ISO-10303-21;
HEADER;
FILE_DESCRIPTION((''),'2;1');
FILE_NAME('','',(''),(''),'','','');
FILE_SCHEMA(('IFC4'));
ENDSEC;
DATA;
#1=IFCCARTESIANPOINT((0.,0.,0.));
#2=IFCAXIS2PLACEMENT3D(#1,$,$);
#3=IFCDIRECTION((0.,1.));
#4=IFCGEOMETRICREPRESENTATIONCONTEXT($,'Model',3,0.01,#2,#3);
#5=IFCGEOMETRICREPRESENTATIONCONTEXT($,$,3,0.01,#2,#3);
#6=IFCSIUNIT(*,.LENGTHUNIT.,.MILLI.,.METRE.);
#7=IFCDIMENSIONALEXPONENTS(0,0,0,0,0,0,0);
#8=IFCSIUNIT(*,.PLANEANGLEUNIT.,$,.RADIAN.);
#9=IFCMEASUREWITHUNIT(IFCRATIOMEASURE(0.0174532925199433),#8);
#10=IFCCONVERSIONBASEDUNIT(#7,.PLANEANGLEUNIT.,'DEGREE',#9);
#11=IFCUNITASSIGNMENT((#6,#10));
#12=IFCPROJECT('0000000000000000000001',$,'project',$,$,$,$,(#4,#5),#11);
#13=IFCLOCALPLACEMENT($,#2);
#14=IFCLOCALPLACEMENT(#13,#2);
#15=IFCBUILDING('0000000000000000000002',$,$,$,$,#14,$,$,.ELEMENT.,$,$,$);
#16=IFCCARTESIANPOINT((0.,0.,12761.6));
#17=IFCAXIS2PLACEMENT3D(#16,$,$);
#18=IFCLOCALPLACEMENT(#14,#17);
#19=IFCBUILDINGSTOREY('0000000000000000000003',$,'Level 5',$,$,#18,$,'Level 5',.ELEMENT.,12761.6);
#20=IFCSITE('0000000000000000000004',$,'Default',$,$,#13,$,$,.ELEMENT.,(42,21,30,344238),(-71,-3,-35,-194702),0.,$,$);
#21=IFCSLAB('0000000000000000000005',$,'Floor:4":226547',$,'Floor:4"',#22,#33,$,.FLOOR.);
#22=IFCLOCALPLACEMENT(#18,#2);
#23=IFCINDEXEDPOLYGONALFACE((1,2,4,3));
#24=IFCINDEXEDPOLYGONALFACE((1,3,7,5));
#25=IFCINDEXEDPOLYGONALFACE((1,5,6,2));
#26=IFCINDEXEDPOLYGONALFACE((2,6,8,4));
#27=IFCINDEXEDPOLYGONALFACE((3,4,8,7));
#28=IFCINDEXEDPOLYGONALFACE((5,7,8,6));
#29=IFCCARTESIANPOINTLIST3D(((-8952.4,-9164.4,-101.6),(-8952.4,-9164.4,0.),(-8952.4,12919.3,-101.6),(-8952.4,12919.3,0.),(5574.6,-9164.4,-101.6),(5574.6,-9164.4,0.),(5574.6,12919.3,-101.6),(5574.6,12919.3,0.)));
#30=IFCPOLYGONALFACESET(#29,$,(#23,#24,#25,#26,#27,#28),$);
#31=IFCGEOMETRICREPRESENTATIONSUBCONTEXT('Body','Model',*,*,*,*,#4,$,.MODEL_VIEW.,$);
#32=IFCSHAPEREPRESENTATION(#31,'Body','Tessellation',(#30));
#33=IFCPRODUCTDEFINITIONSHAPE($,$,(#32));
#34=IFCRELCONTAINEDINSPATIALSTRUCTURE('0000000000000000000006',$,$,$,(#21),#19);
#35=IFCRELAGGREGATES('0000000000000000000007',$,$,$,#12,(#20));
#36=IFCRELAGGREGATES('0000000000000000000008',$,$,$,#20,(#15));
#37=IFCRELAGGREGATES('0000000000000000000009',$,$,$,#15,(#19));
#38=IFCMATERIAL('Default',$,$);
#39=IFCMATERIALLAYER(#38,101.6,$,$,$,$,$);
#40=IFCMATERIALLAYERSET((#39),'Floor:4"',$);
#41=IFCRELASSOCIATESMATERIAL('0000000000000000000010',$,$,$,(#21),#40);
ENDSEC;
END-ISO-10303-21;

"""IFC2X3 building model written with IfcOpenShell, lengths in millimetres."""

from ifc_helpers import new_model, entity, si_unit, converted_unit, direction, frame, frame_2d, origin, place, context, subcontext, project, spatial, rectangle, extrude, material, layer, layer_set, layer_usage, element, save


model = new_model("IFC2X3")

# Units and contexts
model_context = context("Model", 3, precision=0.01, world=origin(), true_north=direction((0.0, 1.0)))
context_of_model = context(None, 3, precision=0.01, world=origin(), true_north=direction((0.0, 1.0)))
body_context = subcontext(model_context, "Body", "Model", "MODEL_VIEW")
ifc_project = project(units=[si_unit("LENGTHUNIT", "METRE", prefix="MILLI"), converted_unit("PLANEANGLEUNIT", "DEGREE", entity("IfcRatioMeasure", 0.0174532925199433), si_unit("PLANEANGLEUNIT", "RADIAN"), dimensions=[0, 0, 0, 0, 0, 0, 0])], contexts=[model_context, context_of_model])

# Site, building, storey
site_placement = place(None, origin())
site = spatial("IfcSite", under=ifc_project, at=site_placement, Name="Default", CompositionType="ELEMENT", RefLatitude=(42, 21, 30, 344238), RefLongitude=(-71, -3, -35, -194702), RefElevation=0.0)
building_placement = place(site_placement, origin())
building = spatial("IfcBuilding", under=site, at=building_placement, CompositionType="ELEMENT")
storey_placement = place(building_placement, frame((0.0, 0.0, 12761.6)))
storey = spatial("IfcBuildingStorey", under=building, at=storey_placement, Name="Level 5", LongName="Level 5", CompositionType="ELEMENT", Elevation=12761.6)

# Slab
ifc_material = material(Name="Default")
ifc_layer = layer(ifc_material, 101.6)
ifc_layer_set = layer_set([ifc_layer], Name="Floor:4\"")
ifc_layer_usage = layer_usage(ifc_layer_set, "AXIS3", "POSITIVE", 0.0)
slab_placement = place(storey_placement, origin())
element("IfcSlab", 1, at=slab_placement, inside=storey, material=ifc_layer_usage, Name="Floor:4\":226547", ObjectType="Floor:4\"", PredefinedType="FLOOR", context=body_context, shape_type="SweptSolid", body=[
    extrude(rectangle(XDim=22083.7, YDim=14527.0, at=frame_2d((0.0, 0.0), x_axis=(1.0, 0.0))), frame((-1688.9, 1877.4, 0.0), z_axis=(0.0, 0.0, -1.0), x_axis=(0.0, 1.0, 0.0)), (0.0, 0.0, 1.0), 101.6),
])

save(model, "model.ifc")
